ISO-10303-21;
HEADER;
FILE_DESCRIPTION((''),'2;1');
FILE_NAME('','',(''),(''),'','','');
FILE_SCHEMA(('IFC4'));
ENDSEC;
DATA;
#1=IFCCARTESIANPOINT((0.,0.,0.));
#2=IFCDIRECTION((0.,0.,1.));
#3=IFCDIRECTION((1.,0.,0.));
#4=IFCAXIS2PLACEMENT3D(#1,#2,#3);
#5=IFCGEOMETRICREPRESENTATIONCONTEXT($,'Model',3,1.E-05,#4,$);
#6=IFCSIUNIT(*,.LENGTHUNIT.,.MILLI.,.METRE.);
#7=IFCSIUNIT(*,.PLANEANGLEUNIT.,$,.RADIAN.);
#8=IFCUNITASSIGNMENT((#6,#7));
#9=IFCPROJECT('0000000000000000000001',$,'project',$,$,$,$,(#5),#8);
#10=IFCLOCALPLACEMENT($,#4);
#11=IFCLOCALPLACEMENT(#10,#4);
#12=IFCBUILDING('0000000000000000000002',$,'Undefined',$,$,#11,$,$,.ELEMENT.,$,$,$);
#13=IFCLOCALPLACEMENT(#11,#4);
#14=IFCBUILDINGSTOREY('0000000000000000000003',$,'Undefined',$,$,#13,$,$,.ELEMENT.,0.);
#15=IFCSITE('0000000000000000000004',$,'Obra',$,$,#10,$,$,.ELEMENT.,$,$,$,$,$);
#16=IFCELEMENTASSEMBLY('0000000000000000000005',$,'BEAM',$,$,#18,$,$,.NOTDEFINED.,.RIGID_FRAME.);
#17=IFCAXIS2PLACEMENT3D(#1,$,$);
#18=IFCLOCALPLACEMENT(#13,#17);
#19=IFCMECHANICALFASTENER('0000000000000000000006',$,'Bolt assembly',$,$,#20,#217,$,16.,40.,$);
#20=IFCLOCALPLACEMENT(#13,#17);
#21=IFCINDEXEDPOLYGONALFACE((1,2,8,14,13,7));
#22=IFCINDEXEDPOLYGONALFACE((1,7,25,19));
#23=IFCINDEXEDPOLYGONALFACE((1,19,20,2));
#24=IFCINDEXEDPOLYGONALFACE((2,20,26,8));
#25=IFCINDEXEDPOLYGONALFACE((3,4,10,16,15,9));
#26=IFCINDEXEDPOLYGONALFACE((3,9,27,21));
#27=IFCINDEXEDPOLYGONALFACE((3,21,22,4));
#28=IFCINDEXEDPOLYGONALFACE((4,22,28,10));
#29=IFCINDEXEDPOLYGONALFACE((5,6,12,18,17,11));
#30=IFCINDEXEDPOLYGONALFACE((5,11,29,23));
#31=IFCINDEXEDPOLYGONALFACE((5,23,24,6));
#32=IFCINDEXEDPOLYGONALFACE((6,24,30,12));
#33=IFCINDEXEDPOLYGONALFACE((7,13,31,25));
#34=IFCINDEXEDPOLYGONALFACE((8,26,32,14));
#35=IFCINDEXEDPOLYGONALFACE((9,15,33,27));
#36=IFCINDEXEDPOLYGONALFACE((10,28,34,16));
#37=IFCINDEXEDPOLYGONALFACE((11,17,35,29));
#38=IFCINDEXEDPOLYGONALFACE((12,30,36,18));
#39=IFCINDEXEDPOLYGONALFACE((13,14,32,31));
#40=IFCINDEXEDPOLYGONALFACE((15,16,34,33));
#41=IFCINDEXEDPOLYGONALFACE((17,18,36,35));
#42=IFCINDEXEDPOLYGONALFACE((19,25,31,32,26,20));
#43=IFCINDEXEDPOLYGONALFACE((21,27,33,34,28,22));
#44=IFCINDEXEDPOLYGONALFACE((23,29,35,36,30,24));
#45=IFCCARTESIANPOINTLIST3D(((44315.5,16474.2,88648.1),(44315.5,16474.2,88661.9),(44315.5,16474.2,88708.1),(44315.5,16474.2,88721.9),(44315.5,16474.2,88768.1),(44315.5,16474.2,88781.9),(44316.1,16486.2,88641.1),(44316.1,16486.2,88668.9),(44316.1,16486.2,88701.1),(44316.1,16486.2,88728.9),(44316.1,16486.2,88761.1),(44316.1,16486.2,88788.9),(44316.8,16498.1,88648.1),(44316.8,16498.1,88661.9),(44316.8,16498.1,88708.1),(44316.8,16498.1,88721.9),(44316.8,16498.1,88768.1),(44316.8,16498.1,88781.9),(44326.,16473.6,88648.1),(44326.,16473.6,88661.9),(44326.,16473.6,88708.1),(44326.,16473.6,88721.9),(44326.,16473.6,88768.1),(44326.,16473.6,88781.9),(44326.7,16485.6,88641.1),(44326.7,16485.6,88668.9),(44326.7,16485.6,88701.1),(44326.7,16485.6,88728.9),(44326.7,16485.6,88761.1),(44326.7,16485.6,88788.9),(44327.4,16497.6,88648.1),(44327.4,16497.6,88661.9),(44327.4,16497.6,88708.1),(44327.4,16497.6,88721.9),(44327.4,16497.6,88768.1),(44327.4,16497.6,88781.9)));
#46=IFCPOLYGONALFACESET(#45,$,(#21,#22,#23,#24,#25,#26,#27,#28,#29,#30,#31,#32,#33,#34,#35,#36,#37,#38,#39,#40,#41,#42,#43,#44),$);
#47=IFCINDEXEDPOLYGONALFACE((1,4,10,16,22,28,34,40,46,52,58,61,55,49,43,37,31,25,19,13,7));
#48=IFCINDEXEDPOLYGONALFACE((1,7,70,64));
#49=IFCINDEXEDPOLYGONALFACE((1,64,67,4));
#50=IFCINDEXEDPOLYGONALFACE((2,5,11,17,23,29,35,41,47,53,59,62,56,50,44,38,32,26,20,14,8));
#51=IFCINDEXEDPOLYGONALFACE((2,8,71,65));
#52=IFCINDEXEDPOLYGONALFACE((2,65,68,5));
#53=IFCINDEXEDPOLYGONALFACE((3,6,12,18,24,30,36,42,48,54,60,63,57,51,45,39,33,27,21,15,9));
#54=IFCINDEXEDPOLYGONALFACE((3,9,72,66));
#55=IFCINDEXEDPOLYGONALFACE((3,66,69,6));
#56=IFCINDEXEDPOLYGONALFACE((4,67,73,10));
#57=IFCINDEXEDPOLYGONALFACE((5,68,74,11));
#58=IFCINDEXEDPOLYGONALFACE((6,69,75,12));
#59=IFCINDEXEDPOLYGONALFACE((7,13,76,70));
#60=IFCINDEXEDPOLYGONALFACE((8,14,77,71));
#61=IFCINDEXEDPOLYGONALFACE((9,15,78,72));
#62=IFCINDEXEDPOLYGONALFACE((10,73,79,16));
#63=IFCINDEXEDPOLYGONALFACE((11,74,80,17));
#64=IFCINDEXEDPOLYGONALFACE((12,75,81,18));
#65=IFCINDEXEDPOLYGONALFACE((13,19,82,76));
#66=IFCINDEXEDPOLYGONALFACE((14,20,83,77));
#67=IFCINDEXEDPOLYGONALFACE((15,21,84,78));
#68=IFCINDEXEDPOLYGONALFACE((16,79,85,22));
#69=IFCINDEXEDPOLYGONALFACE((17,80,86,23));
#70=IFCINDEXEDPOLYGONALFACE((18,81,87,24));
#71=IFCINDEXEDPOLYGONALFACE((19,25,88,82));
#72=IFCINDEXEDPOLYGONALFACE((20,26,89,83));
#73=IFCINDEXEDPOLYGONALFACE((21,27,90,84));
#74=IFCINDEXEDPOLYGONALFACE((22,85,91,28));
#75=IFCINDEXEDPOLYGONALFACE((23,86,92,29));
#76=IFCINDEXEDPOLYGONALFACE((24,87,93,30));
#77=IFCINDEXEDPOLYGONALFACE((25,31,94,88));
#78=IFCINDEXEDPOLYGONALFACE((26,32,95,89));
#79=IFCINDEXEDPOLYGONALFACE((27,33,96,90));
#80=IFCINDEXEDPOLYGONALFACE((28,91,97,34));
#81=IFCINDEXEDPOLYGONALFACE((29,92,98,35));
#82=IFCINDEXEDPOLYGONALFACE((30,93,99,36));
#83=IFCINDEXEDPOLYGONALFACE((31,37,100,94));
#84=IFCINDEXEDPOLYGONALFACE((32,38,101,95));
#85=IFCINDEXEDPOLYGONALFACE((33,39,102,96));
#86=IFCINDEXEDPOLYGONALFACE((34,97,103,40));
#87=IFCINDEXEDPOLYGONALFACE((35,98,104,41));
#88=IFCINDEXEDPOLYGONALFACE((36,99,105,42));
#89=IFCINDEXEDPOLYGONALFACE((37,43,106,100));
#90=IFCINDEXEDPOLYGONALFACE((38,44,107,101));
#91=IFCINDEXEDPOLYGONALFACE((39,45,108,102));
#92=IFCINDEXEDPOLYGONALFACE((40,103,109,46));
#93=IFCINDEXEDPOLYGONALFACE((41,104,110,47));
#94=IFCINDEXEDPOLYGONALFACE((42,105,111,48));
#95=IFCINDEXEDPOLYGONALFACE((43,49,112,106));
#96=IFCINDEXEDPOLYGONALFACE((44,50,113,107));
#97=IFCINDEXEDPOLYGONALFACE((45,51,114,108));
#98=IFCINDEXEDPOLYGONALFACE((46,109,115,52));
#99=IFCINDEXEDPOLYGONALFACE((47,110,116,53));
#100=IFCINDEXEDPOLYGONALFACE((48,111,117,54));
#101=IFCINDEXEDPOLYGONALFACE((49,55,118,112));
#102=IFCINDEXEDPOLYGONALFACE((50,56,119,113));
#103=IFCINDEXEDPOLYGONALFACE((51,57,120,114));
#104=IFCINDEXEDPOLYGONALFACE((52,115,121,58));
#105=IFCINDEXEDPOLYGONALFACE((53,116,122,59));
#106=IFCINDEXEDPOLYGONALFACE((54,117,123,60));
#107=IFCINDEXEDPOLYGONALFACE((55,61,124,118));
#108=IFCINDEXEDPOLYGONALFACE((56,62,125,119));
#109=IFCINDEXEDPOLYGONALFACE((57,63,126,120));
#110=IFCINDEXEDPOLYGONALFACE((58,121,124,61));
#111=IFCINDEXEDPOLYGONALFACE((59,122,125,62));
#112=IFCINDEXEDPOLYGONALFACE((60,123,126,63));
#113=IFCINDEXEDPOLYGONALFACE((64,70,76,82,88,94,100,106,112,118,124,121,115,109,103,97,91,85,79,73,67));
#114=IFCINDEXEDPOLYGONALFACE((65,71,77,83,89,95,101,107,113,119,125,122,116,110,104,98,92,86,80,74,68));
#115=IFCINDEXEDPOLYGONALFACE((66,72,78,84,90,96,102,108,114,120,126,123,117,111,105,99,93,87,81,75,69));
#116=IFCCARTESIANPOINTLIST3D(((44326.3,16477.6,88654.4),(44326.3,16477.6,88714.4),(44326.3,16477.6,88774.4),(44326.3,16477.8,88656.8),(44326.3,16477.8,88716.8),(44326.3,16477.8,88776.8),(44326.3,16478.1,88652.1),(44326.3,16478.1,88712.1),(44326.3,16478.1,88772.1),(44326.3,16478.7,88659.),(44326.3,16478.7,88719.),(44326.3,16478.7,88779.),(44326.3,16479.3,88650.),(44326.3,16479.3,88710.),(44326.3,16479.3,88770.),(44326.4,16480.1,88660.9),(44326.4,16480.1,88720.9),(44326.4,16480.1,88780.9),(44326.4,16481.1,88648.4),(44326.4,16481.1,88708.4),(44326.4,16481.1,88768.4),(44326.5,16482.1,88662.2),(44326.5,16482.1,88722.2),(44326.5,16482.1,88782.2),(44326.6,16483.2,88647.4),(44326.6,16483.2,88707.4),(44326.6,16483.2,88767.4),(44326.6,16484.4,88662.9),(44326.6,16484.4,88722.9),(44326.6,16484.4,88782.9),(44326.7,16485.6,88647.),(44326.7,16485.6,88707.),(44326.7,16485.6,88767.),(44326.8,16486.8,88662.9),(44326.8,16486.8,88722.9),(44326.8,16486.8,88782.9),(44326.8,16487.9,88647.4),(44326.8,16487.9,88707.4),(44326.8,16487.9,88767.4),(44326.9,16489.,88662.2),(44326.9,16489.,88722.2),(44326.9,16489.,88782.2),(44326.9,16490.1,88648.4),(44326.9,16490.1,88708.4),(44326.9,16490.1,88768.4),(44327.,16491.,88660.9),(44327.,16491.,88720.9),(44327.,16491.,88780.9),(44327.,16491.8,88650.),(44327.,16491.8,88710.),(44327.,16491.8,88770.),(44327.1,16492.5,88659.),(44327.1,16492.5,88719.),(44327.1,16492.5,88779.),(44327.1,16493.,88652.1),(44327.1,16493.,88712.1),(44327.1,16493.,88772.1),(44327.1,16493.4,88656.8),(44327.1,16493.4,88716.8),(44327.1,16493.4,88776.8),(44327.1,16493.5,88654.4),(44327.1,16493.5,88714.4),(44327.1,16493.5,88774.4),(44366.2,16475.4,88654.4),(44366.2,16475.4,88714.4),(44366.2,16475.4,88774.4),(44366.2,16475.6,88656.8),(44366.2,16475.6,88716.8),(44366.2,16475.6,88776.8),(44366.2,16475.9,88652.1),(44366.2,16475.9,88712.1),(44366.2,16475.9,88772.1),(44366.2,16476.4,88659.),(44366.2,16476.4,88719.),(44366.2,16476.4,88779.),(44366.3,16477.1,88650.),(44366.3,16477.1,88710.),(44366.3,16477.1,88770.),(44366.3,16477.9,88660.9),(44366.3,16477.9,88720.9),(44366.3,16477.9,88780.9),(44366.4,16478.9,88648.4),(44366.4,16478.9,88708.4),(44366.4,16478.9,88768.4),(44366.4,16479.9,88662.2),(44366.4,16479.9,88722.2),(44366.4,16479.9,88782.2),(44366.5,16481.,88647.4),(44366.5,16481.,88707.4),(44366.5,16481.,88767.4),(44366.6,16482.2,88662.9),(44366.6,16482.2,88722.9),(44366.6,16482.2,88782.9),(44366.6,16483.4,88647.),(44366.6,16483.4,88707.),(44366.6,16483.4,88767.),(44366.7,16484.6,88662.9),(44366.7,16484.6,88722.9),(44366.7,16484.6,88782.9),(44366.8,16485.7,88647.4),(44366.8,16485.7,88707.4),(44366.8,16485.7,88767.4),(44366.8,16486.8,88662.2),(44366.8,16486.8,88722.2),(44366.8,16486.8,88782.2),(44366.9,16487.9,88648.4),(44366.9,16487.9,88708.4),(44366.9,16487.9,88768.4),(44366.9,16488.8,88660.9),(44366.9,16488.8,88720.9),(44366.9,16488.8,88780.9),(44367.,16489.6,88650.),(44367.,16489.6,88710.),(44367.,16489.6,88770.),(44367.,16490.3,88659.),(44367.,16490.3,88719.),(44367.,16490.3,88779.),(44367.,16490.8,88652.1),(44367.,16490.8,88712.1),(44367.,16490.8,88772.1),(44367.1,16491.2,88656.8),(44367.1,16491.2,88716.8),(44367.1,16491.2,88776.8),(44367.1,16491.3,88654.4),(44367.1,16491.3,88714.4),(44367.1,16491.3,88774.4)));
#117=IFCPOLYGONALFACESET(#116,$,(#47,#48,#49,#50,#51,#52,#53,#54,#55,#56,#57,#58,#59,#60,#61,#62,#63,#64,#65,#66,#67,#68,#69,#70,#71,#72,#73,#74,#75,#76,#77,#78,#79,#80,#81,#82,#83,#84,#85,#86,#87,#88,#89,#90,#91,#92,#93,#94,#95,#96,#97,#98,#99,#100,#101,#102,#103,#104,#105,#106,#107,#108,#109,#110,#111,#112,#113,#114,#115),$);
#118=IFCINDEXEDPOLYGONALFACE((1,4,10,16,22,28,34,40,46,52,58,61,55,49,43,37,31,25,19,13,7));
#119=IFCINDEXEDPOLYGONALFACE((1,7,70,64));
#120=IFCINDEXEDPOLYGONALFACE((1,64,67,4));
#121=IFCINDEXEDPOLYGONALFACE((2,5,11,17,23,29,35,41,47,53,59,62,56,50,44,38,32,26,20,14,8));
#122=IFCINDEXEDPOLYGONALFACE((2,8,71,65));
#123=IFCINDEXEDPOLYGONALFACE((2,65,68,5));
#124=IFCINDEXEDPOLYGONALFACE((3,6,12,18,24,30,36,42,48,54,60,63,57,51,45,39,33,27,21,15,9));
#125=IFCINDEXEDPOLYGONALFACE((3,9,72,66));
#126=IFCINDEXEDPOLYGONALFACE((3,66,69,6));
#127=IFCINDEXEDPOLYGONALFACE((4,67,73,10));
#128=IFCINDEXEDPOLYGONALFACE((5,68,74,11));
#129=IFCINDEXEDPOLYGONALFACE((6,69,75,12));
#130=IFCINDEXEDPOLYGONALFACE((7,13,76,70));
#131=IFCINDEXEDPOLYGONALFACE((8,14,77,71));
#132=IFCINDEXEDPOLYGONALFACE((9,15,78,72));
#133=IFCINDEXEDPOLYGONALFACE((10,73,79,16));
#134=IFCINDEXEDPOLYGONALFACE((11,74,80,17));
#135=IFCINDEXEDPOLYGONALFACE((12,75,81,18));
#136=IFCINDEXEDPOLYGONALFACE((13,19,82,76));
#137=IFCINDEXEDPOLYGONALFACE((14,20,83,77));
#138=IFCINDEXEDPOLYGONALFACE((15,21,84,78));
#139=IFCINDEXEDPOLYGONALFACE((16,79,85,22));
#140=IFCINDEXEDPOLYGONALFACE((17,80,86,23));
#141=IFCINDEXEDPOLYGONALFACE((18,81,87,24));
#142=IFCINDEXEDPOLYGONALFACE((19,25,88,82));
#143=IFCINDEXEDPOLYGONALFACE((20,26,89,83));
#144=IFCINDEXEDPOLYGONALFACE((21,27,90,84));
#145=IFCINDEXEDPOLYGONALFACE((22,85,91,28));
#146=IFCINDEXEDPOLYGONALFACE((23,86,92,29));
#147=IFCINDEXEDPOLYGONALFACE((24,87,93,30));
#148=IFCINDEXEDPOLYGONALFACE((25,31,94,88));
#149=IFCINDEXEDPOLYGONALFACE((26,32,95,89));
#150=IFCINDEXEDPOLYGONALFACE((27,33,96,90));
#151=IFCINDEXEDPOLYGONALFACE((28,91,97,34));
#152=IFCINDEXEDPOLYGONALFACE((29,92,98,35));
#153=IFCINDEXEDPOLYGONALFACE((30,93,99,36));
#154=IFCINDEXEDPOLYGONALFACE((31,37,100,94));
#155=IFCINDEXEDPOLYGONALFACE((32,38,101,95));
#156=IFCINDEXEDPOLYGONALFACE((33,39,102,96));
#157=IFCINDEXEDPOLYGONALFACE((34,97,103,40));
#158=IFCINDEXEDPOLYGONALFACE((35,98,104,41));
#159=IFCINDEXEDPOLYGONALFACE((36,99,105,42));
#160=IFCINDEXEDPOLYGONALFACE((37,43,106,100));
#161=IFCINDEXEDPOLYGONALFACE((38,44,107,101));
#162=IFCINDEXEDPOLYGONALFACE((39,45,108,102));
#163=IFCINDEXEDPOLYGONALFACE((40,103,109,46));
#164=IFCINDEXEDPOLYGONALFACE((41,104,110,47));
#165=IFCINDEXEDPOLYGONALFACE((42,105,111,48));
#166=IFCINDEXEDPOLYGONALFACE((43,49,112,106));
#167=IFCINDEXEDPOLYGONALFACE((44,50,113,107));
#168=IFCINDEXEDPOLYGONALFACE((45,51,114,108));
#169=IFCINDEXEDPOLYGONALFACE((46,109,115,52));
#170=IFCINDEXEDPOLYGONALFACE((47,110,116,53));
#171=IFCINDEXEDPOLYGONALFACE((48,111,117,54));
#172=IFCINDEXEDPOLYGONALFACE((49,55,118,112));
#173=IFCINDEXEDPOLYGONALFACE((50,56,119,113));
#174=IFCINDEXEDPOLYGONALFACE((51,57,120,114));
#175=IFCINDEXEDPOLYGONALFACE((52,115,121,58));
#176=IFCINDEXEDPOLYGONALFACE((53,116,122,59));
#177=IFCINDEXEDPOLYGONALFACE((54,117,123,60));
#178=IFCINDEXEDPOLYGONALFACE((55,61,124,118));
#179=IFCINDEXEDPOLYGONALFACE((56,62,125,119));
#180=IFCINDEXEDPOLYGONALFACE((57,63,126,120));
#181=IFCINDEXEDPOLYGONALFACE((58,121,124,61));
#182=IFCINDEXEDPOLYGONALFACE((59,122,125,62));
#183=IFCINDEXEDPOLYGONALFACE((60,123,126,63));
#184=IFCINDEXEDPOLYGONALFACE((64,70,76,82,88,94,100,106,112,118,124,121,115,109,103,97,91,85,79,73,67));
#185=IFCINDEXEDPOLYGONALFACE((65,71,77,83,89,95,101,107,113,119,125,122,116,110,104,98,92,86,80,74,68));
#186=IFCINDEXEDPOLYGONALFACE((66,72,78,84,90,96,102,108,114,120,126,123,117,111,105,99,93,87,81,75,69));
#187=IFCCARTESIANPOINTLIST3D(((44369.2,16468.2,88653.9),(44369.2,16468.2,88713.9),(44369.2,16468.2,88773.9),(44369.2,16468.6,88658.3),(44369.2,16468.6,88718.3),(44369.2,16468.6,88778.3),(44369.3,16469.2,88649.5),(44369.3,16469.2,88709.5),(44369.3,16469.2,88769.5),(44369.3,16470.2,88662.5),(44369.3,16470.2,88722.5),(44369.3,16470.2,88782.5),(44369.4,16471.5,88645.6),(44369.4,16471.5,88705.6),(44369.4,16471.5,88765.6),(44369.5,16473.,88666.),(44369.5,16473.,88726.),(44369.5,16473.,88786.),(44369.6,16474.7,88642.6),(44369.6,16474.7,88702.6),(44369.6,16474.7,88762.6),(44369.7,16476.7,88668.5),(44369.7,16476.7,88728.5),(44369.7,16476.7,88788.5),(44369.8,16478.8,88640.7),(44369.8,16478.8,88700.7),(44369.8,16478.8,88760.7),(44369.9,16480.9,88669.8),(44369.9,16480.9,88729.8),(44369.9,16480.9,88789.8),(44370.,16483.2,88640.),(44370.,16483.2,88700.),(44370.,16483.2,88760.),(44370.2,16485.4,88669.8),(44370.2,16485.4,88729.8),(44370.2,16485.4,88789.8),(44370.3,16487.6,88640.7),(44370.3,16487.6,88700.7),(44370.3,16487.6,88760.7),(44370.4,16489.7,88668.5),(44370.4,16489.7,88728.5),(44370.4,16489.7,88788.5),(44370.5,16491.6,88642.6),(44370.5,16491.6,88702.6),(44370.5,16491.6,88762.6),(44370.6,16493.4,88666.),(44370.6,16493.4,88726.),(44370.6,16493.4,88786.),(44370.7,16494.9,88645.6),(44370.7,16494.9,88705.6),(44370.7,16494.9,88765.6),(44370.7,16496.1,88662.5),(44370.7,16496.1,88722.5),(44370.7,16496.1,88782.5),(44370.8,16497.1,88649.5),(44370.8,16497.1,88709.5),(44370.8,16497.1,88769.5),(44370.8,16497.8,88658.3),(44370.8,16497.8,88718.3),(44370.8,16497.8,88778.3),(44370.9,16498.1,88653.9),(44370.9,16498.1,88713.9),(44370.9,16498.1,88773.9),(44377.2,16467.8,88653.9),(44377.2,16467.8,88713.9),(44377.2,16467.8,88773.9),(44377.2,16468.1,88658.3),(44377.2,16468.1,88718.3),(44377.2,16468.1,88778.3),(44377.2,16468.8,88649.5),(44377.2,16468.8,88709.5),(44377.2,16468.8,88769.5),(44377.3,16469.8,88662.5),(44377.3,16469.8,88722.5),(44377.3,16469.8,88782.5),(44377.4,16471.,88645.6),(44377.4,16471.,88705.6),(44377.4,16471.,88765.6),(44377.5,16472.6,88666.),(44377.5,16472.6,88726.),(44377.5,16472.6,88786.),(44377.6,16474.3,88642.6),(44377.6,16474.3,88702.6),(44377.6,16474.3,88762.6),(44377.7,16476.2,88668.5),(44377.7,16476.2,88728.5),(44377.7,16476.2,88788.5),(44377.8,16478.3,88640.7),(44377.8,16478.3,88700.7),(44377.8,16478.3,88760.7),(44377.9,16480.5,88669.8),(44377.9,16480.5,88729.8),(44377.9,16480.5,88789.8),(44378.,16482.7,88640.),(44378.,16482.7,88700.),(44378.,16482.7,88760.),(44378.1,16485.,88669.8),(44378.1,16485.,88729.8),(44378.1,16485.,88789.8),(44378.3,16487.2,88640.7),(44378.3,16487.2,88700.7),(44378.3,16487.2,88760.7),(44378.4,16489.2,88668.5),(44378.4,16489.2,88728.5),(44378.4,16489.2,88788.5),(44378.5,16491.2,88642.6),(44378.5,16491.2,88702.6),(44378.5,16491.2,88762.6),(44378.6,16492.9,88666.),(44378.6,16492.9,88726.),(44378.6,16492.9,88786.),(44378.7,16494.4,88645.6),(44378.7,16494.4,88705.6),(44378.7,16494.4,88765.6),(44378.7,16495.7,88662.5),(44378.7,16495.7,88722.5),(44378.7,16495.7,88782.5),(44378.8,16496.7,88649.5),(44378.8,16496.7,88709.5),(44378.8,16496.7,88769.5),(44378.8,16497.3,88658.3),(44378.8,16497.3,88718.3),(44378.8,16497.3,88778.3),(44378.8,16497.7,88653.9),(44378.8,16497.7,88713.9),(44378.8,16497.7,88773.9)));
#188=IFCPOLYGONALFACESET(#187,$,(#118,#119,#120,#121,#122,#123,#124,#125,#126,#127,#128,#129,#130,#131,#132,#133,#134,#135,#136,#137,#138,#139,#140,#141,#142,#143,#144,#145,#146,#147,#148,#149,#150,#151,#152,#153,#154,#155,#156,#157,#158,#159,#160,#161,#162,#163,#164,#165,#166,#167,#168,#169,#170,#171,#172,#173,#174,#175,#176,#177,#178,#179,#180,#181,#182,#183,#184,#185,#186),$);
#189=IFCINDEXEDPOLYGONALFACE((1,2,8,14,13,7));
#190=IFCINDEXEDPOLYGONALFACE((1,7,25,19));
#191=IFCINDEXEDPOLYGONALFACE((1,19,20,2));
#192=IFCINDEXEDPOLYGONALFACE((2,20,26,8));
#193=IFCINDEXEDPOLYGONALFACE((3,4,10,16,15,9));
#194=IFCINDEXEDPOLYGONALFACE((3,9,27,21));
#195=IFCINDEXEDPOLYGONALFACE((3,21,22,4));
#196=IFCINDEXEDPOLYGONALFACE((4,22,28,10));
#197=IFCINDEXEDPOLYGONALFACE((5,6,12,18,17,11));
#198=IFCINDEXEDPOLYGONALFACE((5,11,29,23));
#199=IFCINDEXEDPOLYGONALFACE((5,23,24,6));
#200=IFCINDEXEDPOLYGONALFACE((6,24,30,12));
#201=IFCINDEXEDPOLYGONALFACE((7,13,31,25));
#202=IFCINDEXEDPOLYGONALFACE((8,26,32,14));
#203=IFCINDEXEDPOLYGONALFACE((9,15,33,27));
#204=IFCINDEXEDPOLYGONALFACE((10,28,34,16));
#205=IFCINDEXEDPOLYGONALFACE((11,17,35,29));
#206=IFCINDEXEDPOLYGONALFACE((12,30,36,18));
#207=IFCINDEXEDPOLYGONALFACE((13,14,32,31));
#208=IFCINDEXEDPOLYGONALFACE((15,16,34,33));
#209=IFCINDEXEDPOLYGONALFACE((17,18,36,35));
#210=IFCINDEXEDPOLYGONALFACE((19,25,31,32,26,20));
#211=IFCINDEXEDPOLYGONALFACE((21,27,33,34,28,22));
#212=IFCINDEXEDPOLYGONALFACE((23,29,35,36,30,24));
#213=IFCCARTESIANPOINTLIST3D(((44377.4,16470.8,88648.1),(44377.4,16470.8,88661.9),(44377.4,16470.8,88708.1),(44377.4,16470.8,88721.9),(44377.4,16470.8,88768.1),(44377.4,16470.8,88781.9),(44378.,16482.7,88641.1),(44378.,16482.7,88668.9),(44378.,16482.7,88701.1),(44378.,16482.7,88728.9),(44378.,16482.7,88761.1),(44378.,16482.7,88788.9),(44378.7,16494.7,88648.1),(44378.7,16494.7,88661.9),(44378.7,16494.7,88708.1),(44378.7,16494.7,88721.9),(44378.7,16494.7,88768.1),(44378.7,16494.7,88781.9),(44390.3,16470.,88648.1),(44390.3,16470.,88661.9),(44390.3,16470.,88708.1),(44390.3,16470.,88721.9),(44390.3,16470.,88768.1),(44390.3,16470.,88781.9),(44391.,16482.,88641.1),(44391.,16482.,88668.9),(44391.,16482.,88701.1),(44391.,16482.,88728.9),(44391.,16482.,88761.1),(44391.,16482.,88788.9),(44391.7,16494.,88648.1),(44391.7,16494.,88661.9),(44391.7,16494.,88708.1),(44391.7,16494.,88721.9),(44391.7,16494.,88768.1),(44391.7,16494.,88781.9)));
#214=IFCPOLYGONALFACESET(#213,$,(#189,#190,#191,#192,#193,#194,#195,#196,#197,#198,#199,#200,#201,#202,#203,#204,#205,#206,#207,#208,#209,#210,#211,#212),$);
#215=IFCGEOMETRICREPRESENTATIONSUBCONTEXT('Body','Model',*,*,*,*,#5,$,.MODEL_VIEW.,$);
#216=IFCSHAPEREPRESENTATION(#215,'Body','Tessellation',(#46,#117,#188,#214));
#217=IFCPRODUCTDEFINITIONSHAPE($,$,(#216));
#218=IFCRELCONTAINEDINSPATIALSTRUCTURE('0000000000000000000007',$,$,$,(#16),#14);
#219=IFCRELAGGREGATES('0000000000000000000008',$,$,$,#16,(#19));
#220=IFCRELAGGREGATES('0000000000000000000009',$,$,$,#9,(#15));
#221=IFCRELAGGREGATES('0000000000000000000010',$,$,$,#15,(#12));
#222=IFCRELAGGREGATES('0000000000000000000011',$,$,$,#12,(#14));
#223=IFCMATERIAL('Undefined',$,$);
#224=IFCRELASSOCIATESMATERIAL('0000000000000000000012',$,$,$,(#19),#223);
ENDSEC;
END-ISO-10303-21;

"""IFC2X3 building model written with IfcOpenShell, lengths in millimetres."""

from ifc_helpers import new_model, si_unit, frame, origin_with_axes, origin_2d_with_axis, place, context, subcontext, project, spatial, polyline, circle, outline, extrude, source, transform, mapped, material, element, aggregate, save


model = new_model("IFC2X3")

# Units and contexts
model_context = context("Model", 3, precision=1e-05, world=origin_with_axes())
body_context = subcontext(model_context, "Body", "Model", "MODEL_VIEW")
ifc_project = project(units=[si_unit("LENGTHUNIT", "METRE", prefix="MILLI"), si_unit("PLANEANGLEUNIT", "RADIAN")], contexts=[model_context])

# Site, building, storey
site_placement = place(None, origin_with_axes())
site = spatial("IfcSite", under=ifc_project, at=site_placement, Name="Obra", CompositionType="ELEMENT")
building_placement = place(site_placement, origin_with_axes())
building = spatial("IfcBuilding", under=site, at=building_placement, Name="Undefined", CompositionType="ELEMENT")
storey_placement = place(building_placement, origin_with_axes())
storey = spatial("IfcBuildingStorey", under=building, at=storey_placement, Name="Undefined", CompositionType="ELEMENT", Elevation=0.0)

# Element assembly, mechanical fastener
assembly_1_placement = place(storey_placement, origin_with_axes())
assembly_1 = element("IfcElementAssembly", 1, at=assembly_1_placement, inside=storey, Name="BEAM", AssemblyPlace="NOTDEFINED", PredefinedType="RIGID_FRAME")
ifc_material_1 = material(Name="Undefined")
shared_shape_1 = source(origin_with_axes(), body_context, "Body", "SweptSolid", [
    extrude(outline(polyline([(13.9, 0.0), (6.9, 12.0), (-6.9, 12.0), (-13.9, 0.0), (-6.9, -12.0), (6.9, -12.0), (13.9, 0.0)])), frame((0.0, -19.7, 0.0), z_axis=(0.0, 1.0, 0.0), x_axis=(1.0, 0.0, 0.0)), (0.0, 0.0, 1.0), 10.6),
    extrude(circle(Radius=8.0, at=origin_2d_with_axis()), frame((0.0, -9.1, 0.0), z_axis=(0.0, 1.0, 0.0), x_axis=(1.0, 0.0, 0.0)), (0.0, 0.0, 1.0), 40.0),
    extrude(circle(Radius=15.0, at=origin_2d_with_axis()), frame((0.0, 34.3, 0.0), z_axis=(0.0, 1.0, 0.0), x_axis=(1.0, 0.0, 0.0)), (0.0, 0.0, 1.0), 8.0),
    extrude(outline(polyline([(13.9, 0.0), (6.9, 12.0), (-6.9, 12.0), (-13.9, 0.0), (-6.9, -12.0), (6.9, -12.0), (13.9, 0.0)])), frame((0.0, 42.3, 0.0), z_axis=(0.0, 1.0, 0.0), x_axis=(1.0, 0.0, 0.0)), (0.0, 0.0, 1.0), 13.0),
])
mechanical_fastener_1_placement = place(assembly_1_placement, frame((44338.5, 16535.0, 88835.0), z_axis=(-0.055268, -0.998472, 0.0), x_axis=(0.0, 0.0, -1.0)))
mechanical_fastener_1 = element("IfcMechanicalFastener", 2, at=mechanical_fastener_1_placement, material=ifc_material_1, Name="Bolt assembly", NominalDiameter=16.0, NominalLength=40.0, context=body_context, shape_type="MappedRepresentation", body=[
    mapped(shared_shape_1, transform((60.0, 0.0, 50.0))),
    mapped(shared_shape_1, transform((120.0, 0.0, 50.0))),
    mapped(shared_shape_1, transform((180.0, 0.0, 50.0))),
])
aggregate(assembly_1, [mechanical_fastener_1])

save(model, "model.ifc")
